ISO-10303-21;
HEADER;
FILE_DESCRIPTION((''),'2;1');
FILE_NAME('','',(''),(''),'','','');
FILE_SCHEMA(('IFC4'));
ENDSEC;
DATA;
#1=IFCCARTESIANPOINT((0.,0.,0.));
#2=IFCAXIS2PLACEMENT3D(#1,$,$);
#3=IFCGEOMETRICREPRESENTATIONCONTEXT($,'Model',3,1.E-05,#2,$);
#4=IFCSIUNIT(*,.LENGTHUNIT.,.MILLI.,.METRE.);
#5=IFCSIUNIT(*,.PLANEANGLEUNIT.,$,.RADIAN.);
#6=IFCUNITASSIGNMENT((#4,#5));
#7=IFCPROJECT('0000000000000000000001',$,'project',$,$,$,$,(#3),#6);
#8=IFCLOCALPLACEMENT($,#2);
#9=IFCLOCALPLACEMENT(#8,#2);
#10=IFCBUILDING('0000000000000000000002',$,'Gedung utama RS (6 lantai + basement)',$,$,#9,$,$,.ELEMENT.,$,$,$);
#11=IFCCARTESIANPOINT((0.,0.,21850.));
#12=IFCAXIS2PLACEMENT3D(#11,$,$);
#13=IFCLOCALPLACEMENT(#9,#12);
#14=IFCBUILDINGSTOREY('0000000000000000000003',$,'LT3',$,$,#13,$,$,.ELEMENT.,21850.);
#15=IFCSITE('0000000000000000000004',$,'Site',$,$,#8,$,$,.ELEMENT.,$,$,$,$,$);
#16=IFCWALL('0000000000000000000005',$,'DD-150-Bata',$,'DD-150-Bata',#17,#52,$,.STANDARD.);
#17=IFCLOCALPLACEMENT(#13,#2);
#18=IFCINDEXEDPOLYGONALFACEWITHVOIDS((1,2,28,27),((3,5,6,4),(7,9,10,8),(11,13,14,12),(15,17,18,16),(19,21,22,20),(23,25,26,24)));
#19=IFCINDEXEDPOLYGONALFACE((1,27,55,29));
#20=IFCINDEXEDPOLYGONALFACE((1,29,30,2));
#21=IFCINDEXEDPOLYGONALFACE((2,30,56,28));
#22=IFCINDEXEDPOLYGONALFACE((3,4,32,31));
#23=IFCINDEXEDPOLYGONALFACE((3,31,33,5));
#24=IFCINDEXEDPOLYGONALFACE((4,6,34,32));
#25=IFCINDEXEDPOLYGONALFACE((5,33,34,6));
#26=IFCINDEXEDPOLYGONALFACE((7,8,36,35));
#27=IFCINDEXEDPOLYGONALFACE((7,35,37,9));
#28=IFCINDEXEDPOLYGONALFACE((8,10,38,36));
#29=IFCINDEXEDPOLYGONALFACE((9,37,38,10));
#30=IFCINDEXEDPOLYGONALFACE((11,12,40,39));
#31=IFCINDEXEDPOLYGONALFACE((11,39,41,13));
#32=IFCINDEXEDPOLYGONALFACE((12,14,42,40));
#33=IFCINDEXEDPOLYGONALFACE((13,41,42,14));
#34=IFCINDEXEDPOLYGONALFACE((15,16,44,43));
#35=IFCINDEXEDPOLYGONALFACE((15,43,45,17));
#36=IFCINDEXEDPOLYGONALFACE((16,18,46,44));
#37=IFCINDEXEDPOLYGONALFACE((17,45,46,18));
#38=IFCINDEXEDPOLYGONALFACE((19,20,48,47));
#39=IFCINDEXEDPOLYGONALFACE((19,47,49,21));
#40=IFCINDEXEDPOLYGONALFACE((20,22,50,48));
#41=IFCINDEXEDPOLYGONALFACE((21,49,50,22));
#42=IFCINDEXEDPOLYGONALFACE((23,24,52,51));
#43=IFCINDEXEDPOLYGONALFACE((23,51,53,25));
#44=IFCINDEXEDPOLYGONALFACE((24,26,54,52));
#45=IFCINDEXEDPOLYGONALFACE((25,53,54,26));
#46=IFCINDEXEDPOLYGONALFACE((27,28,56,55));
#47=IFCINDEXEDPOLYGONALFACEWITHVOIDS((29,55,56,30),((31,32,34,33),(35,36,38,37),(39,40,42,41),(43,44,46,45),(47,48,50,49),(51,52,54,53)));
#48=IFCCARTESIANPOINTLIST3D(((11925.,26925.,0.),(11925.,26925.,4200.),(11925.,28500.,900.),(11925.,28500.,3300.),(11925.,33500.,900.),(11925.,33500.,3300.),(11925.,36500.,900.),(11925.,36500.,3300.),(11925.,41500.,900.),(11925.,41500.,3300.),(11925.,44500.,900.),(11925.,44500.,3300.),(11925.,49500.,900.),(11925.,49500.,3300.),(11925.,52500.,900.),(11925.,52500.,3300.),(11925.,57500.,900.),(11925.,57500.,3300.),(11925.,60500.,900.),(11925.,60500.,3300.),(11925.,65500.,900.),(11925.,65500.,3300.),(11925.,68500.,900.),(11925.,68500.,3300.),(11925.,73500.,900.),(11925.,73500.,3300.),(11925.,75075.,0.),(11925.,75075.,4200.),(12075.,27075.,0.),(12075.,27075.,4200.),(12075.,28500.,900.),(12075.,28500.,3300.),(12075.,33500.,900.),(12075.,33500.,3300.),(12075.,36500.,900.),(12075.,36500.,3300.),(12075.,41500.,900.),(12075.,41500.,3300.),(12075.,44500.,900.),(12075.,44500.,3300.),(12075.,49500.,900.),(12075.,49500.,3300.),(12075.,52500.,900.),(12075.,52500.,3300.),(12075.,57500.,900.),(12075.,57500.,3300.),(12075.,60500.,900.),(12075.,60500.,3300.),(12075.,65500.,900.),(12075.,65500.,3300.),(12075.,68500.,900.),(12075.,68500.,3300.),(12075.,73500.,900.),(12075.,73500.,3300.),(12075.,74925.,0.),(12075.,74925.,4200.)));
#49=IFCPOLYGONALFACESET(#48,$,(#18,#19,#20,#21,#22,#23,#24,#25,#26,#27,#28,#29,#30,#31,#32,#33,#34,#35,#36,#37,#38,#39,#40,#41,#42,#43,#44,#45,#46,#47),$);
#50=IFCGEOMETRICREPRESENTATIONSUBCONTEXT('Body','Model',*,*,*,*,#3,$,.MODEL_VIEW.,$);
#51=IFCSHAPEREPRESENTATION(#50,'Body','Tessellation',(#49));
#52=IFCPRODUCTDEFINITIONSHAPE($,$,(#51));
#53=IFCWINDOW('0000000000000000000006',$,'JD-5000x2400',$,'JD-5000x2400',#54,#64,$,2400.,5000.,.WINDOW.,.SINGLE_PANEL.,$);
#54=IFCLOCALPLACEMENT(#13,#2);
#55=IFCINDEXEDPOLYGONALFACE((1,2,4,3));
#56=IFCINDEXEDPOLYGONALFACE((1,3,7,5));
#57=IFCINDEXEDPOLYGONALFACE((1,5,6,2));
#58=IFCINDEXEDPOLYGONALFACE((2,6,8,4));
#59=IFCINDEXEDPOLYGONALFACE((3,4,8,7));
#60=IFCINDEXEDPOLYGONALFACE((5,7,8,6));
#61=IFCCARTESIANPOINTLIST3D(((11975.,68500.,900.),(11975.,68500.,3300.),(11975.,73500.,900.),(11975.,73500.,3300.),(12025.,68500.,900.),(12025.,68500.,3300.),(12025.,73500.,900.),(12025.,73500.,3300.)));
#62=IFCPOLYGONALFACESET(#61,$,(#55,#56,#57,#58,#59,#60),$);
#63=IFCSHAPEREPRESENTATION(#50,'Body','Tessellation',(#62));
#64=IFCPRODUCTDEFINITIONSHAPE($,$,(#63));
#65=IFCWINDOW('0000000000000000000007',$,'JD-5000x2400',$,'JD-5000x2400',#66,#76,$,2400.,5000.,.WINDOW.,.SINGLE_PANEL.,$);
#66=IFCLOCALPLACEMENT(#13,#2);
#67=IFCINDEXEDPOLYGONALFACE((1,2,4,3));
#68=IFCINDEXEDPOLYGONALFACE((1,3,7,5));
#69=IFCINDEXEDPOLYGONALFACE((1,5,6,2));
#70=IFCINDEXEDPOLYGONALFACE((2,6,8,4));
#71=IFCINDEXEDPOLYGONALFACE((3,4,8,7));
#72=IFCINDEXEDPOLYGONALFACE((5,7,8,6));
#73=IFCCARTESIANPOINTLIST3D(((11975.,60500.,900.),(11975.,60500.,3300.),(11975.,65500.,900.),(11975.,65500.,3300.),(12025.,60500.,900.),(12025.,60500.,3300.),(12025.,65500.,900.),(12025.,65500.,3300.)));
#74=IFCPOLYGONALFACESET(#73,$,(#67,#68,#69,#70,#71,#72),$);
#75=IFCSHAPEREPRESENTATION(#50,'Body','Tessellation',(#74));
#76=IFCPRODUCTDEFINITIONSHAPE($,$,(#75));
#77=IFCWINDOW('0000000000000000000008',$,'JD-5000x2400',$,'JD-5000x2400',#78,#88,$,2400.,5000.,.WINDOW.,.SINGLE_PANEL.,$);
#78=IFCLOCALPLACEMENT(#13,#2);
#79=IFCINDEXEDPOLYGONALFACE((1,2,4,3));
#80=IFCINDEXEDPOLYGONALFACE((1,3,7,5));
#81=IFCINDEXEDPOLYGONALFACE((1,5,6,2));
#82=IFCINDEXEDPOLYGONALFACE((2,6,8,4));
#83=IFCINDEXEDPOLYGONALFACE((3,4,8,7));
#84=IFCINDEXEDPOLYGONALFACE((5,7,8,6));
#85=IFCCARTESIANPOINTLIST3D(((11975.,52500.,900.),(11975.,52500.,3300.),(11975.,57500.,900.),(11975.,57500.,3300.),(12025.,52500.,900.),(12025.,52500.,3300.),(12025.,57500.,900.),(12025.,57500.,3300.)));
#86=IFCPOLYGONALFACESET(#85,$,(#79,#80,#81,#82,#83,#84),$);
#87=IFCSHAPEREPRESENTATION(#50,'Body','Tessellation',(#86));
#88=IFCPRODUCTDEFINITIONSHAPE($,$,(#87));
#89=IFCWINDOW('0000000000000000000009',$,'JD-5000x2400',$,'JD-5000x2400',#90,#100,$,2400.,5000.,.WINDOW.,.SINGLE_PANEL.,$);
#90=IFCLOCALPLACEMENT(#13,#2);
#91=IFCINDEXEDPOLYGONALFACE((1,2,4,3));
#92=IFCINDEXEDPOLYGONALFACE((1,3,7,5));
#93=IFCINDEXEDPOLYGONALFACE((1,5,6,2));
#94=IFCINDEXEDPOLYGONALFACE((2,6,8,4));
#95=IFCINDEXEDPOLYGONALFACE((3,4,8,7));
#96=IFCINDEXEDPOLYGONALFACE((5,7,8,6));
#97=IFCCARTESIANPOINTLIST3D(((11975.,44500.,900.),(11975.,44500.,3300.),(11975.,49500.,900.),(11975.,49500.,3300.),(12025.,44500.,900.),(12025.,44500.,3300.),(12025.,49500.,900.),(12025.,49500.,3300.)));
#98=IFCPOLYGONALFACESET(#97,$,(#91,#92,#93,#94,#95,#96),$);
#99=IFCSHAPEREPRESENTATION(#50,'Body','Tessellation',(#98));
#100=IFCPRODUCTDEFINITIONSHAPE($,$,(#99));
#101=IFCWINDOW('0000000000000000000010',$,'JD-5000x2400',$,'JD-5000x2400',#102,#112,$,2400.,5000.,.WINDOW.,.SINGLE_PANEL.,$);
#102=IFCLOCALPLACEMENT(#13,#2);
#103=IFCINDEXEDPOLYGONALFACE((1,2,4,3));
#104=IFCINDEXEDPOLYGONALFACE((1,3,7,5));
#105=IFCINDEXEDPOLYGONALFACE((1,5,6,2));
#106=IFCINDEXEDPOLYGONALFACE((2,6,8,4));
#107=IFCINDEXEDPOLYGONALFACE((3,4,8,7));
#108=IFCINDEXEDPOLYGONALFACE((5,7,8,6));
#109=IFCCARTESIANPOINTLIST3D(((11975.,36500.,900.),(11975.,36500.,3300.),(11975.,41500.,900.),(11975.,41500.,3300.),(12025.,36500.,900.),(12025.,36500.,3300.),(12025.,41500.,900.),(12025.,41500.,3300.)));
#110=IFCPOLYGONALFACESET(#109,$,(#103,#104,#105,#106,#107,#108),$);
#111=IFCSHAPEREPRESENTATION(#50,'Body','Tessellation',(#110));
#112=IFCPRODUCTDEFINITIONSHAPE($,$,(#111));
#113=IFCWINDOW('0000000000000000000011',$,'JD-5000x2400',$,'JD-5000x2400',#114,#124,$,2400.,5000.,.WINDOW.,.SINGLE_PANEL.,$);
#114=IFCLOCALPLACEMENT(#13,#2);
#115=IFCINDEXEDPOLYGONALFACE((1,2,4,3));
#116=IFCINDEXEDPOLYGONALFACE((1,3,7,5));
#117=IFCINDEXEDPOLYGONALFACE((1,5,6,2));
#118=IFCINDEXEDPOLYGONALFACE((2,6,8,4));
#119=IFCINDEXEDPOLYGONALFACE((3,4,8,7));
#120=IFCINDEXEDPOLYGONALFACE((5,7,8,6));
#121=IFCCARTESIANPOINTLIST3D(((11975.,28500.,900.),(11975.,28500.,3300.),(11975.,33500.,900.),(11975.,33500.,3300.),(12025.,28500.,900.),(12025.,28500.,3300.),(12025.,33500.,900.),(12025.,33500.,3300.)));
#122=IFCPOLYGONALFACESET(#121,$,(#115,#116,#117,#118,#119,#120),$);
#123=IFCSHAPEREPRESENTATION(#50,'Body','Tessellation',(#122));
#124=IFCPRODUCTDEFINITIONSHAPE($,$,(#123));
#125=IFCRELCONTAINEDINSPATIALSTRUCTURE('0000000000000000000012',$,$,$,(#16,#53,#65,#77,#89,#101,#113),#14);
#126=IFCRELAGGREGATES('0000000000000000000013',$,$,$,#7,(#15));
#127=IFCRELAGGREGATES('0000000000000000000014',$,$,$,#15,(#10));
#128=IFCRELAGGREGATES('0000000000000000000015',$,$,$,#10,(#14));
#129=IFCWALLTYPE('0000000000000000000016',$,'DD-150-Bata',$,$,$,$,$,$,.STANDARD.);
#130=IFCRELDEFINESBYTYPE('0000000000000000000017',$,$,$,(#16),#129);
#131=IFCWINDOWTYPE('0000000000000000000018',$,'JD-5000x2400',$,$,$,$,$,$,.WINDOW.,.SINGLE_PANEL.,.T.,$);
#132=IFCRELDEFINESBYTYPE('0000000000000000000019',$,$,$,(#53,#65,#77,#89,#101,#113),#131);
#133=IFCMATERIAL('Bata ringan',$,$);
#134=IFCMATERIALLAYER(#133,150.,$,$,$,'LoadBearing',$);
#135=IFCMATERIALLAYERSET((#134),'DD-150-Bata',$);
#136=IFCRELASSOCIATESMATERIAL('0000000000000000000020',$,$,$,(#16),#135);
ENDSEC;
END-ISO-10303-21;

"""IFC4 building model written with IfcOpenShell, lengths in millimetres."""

from ifc_helpers import new_model, si_unit, frame, frame_2d, origin, place, context, subcontext, project, spatial, polyline, rectangle, outline, extrude, material, layer, layer_set, layer_usage, type_object, element, fill, save


model = new_model("IFC4")

# Units and contexts
model_context = context("Model", 3, precision=1e-05, world=origin())
body_context = subcontext(model_context, "Body", "Model", "MODEL_VIEW")
ifc_project = project(units=[si_unit("LENGTHUNIT", "METRE", prefix="MILLI"), si_unit("PLANEANGLEUNIT", "RADIAN")], contexts=[model_context])

# Site, building, storey
site_placement = place(None, origin())
site = spatial("IfcSite", under=ifc_project, at=site_placement, Name="Site", CompositionType="ELEMENT")
building_placement = place(site_placement, origin())
building = spatial("IfcBuilding", under=site, at=building_placement, Name="Gedung utama RS (6 lantai + basement)", CompositionType="ELEMENT")
storey_placement = place(building_placement, frame((0.0, 0.0, 21850.0)))
storey = spatial("IfcBuildingStorey", under=building, at=storey_placement, Name="LT3", CompositionType="ELEMENT", Elevation=21850.0)

# Wall, openings, windows
ifc_material_1 = material(Name="Bata ringan")
ifc_layer = layer(ifc_material_1, 150.0, Category="LoadBearing")
ifc_layer_set = layer_set([ifc_layer], Name="DD-150-Bata")
ifc_layer_usage = layer_usage(ifc_layer_set, "AXIS2", "NEGATIVE", 75.0)
wall_type = type_object("IfcWallType", Name="DD-150-Bata", PredefinedType="STANDARD")
wall_placement = place(storey_placement, frame((12000.0, 75000.0, 0.0), z_axis=(0.0, 0.0, 1.0), x_axis=(0.0, -1.0, 0.0)))
wall = element("IfcWall", 1, at=wall_placement, inside=storey, type_object=wall_type, material=ifc_layer_usage, Name="DD-150-Bata", ObjectType="DD-150-Bata", PredefinedType="STANDARD", context=body_context, shape_type="SweptSolid", body=[
    extrude(outline(polyline([(-75.0, -75.0), (0.0, 0.0), (75.0, 75.0), (47925.0, 75.0), (48000.0, 0.0), (48075.0, -75.0), (-75.0, -75.0)])), origin(), (0.0, 0.0, 1.0), 4200.0),
])
opening_1_placement = place(wall_placement, frame((1500.0, 0.0, 900.0), z_axis=(0.0, 0.0, 1.0), x_axis=(1.0, 0.0, 0.0)))
opening_1 = element("IfcOpeningElement", 2, at=opening_1_placement, cuts=wall, PredefinedType="OPENING", context=body_context, shape_type="SweptSolid", body=[
    extrude(rectangle(XDim=5000.0, YDim=170.0, at=frame_2d((2500.0, 0.0))), origin(), (0.0, 0.0, 1.0), 2400.0),
])
opening_2_placement = place(wall_placement, frame((9500.0, 0.0, 900.0), z_axis=(0.0, 0.0, 1.0), x_axis=(1.0, 0.0, 0.0)))
opening_2 = element("IfcOpeningElement", 3, at=opening_2_placement, cuts=wall, PredefinedType="OPENING", context=body_context, shape_type="SweptSolid", body=[
    extrude(rectangle(XDim=5000.0, YDim=170.0, at=frame_2d((2500.0, 0.0))), origin(), (0.0, 0.0, 1.0), 2400.0),
])
opening_3_placement = place(wall_placement, frame((17500.0, 0.0, 900.0), z_axis=(0.0, 0.0, 1.0), x_axis=(1.0, 0.0, 0.0)))
opening_3 = element("IfcOpeningElement", 4, at=opening_3_placement, cuts=wall, PredefinedType="OPENING", context=body_context, shape_type="SweptSolid", body=[
    extrude(rectangle(XDim=5000.0, YDim=170.0, at=frame_2d((2500.0, 0.0))), origin(), (0.0, 0.0, 1.0), 2400.0),
])
opening_4_placement = place(wall_placement, frame((25500.0, 0.0, 900.0), z_axis=(0.0, 0.0, 1.0), x_axis=(1.0, 0.0, 0.0)))
opening_4 = element("IfcOpeningElement", 5, at=opening_4_placement, cuts=wall, PredefinedType="OPENING", context=body_context, shape_type="SweptSolid", body=[
    extrude(rectangle(XDim=5000.0, YDim=170.0, at=frame_2d((2500.0, 0.0))), origin(), (0.0, 0.0, 1.0), 2400.0),
])
opening_5_placement = place(wall_placement, frame((33500.0, 0.0, 900.0), z_axis=(0.0, 0.0, 1.0), x_axis=(1.0, 0.0, 0.0)))
opening_5 = element("IfcOpeningElement", 6, at=opening_5_placement, cuts=wall, PredefinedType="OPENING", context=body_context, shape_type="SweptSolid", body=[
    extrude(rectangle(XDim=5000.0, YDim=170.0, at=frame_2d((2500.0, 0.0))), origin(), (0.0, 0.0, 1.0), 2400.0),
])
opening_6_placement = place(wall_placement, frame((41500.0, 0.0, 900.0), z_axis=(0.0, 0.0, 1.0), x_axis=(1.0, 0.0, 0.0)))
opening_6 = element("IfcOpeningElement", 7, at=opening_6_placement, cuts=wall, PredefinedType="OPENING", context=body_context, shape_type="SweptSolid", body=[
    extrude(rectangle(XDim=5000.0, YDim=170.0, at=frame_2d((2500.0, 0.0))), origin(), (0.0, 0.0, 1.0), 2400.0),
])
window_type = type_object("IfcWindowType", Name="JD-5000x2400", ParameterTakesPrecedence=True, PartitioningType="SINGLE_PANEL", PredefinedType="WINDOW")
window_1_placement = place(opening_1_placement, origin())
window_1 = element("IfcWindow", 8, at=window_1_placement, inside=storey, type_object=window_type, Name="JD-5000x2400", ObjectType="JD-5000x2400", OverallHeight=2400.0, OverallWidth=5000.0, PartitioningType="SINGLE_PANEL", PredefinedType="WINDOW", context=body_context, shape_type="SweptSolid", body=[
    extrude(rectangle(XDim=5000.0, YDim=50.0, at=frame_2d((2500.0, 0.0))), origin(), (0.0, 0.0, 1.0), 2400.0),
])
fill(opening_1, window_1)
window_2_placement = place(opening_2_placement, origin())
window_2 = element("IfcWindow", 9, at=window_2_placement, inside=storey, type_object=window_type, Name="JD-5000x2400", ObjectType="JD-5000x2400", OverallHeight=2400.0, OverallWidth=5000.0, PartitioningType="SINGLE_PANEL", PredefinedType="WINDOW", context=body_context, shape_type="SweptSolid", body=[
    extrude(rectangle(XDim=5000.0, YDim=50.0, at=frame_2d((2500.0, 0.0))), origin(), (0.0, 0.0, 1.0), 2400.0),
])
fill(opening_2, window_2)
window_3_placement = place(opening_3_placement, origin())
window_3 = element("IfcWindow", 10, at=window_3_placement, inside=storey, type_object=window_type, Name="JD-5000x2400", ObjectType="JD-5000x2400", OverallHeight=2400.0, OverallWidth=5000.0, PartitioningType="SINGLE_PANEL", PredefinedType="WINDOW", context=body_context, shape_type="SweptSolid", body=[
    extrude(rectangle(XDim=5000.0, YDim=50.0, at=frame_2d((2500.0, 0.0))), origin(), (0.0, 0.0, 1.0), 2400.0),
])
fill(opening_3, window_3)
window_4_placement = place(opening_4_placement, origin())
window_4 = element("IfcWindow", 11, at=window_4_placement, inside=storey, type_object=window_type, Name="JD-5000x2400", ObjectType="JD-5000x2400", OverallHeight=2400.0, OverallWidth=5000.0, PartitioningType="SINGLE_PANEL", PredefinedType="WINDOW", context=body_context, shape_type="SweptSolid", body=[
    extrude(rectangle(XDim=5000.0, YDim=50.0, at=frame_2d((2500.0, 0.0))), origin(), (0.0, 0.0, 1.0), 2400.0),
])
fill(opening_4, window_4)
window_5_placement = place(opening_5_placement, origin())
window_5 = element("IfcWindow", 12, at=window_5_placement, inside=storey, type_object=window_type, Name="JD-5000x2400", ObjectType="JD-5000x2400", OverallHeight=2400.0, OverallWidth=5000.0, PartitioningType="SINGLE_PANEL", PredefinedType="WINDOW", context=body_context, shape_type="SweptSolid", body=[
    extrude(rectangle(XDim=5000.0, YDim=50.0, at=frame_2d((2500.0, 0.0))), origin(), (0.0, 0.0, 1.0), 2400.0),
])
fill(opening_5, window_5)
window_6_placement = place(opening_6_placement, origin())
window_6 = element("IfcWindow", 13, at=window_6_placement, inside=storey, type_object=window_type, Name="JD-5000x2400", ObjectType="JD-5000x2400", OverallHeight=2400.0, OverallWidth=5000.0, PartitioningType="SINGLE_PANEL", PredefinedType="WINDOW", context=body_context, shape_type="SweptSolid", body=[
    extrude(rectangle(XDim=5000.0, YDim=50.0, at=frame_2d((2500.0, 0.0))), origin(), (0.0, 0.0, 1.0), 2400.0),
])
fill(opening_6, window_6)

save(model, "model.ifc")
